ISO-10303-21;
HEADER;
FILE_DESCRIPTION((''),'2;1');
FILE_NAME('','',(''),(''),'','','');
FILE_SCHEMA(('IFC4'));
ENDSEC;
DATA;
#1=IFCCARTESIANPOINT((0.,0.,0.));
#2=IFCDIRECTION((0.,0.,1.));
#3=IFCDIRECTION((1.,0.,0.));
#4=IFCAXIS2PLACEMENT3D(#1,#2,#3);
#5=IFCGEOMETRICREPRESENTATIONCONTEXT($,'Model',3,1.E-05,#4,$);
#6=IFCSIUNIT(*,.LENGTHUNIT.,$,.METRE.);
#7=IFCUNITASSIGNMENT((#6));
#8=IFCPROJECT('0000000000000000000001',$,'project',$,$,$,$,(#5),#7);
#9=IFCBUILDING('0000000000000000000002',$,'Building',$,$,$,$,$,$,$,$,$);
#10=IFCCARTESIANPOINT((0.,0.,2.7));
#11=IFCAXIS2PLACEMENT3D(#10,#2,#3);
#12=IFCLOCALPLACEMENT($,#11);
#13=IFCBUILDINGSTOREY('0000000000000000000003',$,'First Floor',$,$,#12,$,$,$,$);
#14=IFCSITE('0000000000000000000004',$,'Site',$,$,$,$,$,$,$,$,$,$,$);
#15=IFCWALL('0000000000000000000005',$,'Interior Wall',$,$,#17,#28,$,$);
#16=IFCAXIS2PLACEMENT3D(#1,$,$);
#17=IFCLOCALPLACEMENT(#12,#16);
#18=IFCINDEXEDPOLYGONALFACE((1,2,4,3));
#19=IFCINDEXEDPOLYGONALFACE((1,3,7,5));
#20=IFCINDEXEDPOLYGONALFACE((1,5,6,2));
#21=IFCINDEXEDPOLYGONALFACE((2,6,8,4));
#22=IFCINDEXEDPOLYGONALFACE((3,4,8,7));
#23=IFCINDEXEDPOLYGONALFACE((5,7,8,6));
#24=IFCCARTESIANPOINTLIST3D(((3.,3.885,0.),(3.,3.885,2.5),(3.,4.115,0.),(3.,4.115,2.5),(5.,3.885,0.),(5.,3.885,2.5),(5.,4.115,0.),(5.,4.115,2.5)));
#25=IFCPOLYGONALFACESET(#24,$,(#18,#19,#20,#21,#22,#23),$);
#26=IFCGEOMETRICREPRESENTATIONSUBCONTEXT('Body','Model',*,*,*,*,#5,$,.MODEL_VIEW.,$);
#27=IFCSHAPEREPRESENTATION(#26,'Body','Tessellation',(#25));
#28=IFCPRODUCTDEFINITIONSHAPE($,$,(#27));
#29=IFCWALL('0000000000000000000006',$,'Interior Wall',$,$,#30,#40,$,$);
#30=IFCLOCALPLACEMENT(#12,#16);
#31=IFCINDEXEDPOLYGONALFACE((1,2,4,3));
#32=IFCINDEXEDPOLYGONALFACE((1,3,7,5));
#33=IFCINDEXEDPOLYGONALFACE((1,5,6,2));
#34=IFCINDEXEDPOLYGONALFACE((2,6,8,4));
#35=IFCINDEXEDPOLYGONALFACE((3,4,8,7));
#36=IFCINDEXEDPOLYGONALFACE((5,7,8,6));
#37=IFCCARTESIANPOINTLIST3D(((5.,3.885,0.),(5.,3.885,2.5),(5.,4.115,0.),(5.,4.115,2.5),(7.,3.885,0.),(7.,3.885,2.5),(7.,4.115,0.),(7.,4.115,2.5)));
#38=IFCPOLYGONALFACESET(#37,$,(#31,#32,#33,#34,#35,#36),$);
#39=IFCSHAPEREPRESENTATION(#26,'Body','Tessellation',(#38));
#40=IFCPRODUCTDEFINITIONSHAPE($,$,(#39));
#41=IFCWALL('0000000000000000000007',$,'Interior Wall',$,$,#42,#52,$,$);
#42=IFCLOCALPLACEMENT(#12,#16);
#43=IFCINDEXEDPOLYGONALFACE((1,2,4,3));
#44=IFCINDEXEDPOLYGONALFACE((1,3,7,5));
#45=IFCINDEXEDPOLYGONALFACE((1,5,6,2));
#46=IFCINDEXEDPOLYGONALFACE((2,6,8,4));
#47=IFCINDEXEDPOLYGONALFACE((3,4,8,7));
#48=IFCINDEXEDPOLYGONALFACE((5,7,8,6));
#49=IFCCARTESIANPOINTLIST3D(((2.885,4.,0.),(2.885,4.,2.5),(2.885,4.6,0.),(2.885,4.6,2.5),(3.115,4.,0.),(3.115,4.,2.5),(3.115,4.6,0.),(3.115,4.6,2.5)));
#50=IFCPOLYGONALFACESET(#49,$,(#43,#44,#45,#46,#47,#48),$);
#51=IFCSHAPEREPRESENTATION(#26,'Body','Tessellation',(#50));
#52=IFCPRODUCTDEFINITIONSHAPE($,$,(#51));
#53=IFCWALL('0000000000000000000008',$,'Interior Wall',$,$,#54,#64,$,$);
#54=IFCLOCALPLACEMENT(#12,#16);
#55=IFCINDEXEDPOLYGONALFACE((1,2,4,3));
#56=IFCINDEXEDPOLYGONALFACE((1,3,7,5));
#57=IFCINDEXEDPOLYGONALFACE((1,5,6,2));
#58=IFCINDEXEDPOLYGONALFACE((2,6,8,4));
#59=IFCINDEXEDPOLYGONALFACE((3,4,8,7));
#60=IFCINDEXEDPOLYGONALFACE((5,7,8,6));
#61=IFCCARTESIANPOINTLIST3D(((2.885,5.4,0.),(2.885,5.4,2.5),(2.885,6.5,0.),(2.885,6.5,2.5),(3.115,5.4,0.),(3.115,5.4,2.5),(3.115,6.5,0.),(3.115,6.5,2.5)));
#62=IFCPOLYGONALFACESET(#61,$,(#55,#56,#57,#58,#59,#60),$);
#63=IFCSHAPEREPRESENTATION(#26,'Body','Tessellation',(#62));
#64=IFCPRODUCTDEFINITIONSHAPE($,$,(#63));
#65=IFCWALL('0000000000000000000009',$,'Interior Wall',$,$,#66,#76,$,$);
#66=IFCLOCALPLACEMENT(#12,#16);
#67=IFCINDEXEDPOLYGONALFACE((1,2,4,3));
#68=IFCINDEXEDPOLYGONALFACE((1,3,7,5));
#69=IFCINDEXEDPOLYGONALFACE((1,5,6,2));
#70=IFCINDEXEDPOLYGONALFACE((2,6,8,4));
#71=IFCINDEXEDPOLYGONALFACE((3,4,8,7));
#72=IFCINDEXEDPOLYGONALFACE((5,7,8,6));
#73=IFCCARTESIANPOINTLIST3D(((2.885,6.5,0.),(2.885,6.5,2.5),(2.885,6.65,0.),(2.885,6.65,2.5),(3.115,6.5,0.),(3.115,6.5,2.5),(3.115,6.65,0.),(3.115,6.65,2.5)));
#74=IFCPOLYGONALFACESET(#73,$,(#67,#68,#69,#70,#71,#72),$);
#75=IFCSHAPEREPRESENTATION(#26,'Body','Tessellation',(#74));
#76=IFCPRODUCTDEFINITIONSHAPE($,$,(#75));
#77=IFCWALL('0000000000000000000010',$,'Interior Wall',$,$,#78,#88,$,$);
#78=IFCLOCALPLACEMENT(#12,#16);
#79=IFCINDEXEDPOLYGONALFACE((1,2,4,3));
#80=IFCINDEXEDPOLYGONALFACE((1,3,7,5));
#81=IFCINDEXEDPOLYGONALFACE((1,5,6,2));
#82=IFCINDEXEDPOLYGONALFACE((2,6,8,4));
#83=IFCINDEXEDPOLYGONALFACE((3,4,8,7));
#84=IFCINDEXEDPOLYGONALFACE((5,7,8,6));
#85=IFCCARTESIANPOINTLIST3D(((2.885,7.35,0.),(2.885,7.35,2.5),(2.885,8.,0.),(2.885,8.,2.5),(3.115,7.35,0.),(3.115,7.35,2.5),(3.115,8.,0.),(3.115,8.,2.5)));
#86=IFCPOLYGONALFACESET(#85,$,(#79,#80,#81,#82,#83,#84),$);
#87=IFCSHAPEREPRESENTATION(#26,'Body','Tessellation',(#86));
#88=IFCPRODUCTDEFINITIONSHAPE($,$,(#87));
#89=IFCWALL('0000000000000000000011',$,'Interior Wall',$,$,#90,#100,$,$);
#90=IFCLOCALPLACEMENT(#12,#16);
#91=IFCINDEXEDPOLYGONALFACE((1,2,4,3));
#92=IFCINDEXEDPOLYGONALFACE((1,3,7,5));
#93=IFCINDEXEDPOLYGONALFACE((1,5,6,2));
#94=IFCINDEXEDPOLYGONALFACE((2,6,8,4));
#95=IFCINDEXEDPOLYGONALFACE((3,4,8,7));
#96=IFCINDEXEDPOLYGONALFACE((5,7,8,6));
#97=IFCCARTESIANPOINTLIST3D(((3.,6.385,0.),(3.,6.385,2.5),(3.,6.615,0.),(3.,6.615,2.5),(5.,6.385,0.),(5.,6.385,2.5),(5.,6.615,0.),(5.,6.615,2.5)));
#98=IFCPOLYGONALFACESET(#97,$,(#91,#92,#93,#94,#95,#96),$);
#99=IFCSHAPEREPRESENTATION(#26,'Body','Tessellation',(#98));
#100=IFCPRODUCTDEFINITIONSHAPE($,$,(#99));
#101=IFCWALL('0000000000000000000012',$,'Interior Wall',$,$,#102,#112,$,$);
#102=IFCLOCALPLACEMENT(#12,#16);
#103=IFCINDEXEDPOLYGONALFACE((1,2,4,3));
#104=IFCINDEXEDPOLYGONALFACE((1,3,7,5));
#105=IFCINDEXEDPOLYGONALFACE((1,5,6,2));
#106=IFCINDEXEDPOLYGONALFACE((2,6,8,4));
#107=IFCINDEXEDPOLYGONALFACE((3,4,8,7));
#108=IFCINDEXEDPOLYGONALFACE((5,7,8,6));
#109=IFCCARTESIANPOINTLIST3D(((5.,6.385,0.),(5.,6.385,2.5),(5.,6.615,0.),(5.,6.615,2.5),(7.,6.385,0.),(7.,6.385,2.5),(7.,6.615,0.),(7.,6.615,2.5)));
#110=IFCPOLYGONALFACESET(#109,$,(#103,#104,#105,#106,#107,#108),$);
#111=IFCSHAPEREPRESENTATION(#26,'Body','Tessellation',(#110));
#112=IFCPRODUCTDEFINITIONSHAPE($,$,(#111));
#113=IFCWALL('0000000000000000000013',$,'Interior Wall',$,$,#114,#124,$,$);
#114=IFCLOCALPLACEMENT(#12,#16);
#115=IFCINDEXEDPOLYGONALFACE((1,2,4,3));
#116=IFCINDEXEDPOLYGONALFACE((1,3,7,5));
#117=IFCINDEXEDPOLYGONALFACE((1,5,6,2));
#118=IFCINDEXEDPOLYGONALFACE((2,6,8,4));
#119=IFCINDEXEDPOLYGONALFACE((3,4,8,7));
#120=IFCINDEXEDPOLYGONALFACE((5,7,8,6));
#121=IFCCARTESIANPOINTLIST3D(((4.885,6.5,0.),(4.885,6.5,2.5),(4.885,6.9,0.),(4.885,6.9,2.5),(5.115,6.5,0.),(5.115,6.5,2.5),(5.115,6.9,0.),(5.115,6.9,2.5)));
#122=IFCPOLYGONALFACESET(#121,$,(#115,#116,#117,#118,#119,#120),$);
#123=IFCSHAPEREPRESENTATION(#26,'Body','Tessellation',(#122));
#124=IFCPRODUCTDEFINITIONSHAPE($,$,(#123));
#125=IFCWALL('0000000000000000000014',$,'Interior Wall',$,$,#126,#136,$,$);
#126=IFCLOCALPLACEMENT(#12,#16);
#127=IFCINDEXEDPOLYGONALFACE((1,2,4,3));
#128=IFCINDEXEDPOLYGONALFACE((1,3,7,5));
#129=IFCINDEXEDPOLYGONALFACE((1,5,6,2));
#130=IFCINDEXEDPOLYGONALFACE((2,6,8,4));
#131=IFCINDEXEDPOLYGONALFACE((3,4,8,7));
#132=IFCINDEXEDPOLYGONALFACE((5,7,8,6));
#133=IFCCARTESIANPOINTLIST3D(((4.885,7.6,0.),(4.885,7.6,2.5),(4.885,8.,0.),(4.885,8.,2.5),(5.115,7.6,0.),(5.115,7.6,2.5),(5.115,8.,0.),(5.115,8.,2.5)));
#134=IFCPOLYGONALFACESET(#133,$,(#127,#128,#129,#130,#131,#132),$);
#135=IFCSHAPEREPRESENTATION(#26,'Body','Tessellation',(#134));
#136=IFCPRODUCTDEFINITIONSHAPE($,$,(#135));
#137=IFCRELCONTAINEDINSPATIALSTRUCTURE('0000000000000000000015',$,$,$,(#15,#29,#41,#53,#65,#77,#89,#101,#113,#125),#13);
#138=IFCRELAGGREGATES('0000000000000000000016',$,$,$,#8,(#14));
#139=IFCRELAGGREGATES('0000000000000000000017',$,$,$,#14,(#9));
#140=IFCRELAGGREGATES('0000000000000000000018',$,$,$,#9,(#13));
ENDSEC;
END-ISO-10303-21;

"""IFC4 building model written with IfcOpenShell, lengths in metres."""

from ifc_helpers import new_model, si_unit, frame, origin_with_axes, place, context, subcontext, project, spatial, indexed_curve, outline, extrude, element, save


model = new_model("IFC4")

# Units and contexts
model_context = context("Model", 3, precision=1e-05, world=origin_with_axes())
body_context = subcontext(model_context, "Body", "Model", "MODEL_VIEW")
ifc_project = project(units=[si_unit("LENGTHUNIT", "METRE")], contexts=[model_context])

# Site, building, storey
site = spatial("IfcSite", under=ifc_project, Name="Site")
building = spatial("IfcBuilding", under=site, Name="Building")
storey_placement = place(None, frame((0.0, 0.0, 2.7), z_axis=(0.0, 0.0, 1.0), x_axis=(1.0, 0.0, 0.0)))
storey = spatial("IfcBuildingStorey", under=building, at=storey_placement, Name="First Floor")

# Walls
for number, where, z_axis, x_axis, name in (
    (1, (5.0, 4.0, 0.0), (0.0, 0.0, 1.0), (-1.0, 0.0, 0.0), "Interior Wall"),
    (2, (7.0, 4.0, 0.0), (0.0, 0.0, 1.0), (-1.0, 0.0, 0.0), "Interior Wall"),
):
    element("IfcWall", number, at=place(storey_placement, frame(where, z_axis=z_axis, x_axis=x_axis)), inside=storey, Name=name, context=body_context, shape_type="SweptSolid", body=[
        extrude(outline(indexed_curve([(0.0, 0.0), (0.0, 0.23), (2.0, 0.23), (2.0, 0.0), (0.0, 0.0)], self_intersect=False)), frame((0.0, -0.115, 0.0), z_axis=(0.0, 0.0, 1.0), x_axis=(1.0, 0.0, 0.0)), (0.0, 0.0, 1.0), 2.5),
    ])
wall_1_placement = place(storey_placement, frame((3.0, 4.0, 0.0), z_axis=(0.0, 0.0, 1.0), x_axis=(0.0, 1.0, 0.0)))
element("IfcWall", 3, at=wall_1_placement, inside=storey, Name="Interior Wall", context=body_context, shape_type="SweptSolid", body=[
    extrude(outline(indexed_curve([(0.0, 0.0), (0.0, 0.23), (0.6, 0.23), (0.6, 0.0), (0.0, 0.0)], self_intersect=False)), frame((0.0, -0.115, 0.0), z_axis=(0.0, 0.0, 1.0), x_axis=(1.0, 0.0, 0.0)), (0.0, 0.0, 1.0), 2.5),
])
wall_2_placement = place(storey_placement, frame((3.0, 5.4, 0.0), z_axis=(0.0, 0.0, 1.0), x_axis=(0.0, 1.0, 0.0)))
element("IfcWall", 4, at=wall_2_placement, inside=storey, Name="Interior Wall", context=body_context, shape_type="SweptSolid", body=[
    extrude(outline(indexed_curve([(0.0, 0.0), (0.0, 0.23), (1.1, 0.23), (1.1, 0.0), (0.0, 0.0)], self_intersect=False)), frame((0.0, -0.115, 0.0), z_axis=(0.0, 0.0, 1.0), x_axis=(1.0, 0.0, 0.0)), (0.0, 0.0, 1.0), 2.5),
])
wall_3_placement = place(storey_placement, frame((3.0, 6.5, 0.0), z_axis=(0.0, 0.0, 1.0), x_axis=(0.0, 1.0, 0.0)))
element("IfcWall", 5, at=wall_3_placement, inside=storey, Name="Interior Wall", context=body_context, shape_type="SweptSolid", body=[
    extrude(outline(indexed_curve([(0.0, 0.0), (0.0, 0.23), (0.15, 0.23), (0.15, 0.0), (0.0, 0.0)], self_intersect=False)), frame((0.0, -0.115, 0.0), z_axis=(0.0, 0.0, 1.0), x_axis=(1.0, 0.0, 0.0)), (0.0, 0.0, 1.0), 2.5),
])
wall_4_placement = place(storey_placement, frame((3.0, 7.35, 0.0), z_axis=(0.0, 0.0, 1.0), x_axis=(0.0, 1.0, 0.0)))
element("IfcWall", 6, at=wall_4_placement, inside=storey, Name="Interior Wall", context=body_context, shape_type="SweptSolid", body=[
    extrude(outline(indexed_curve([(0.0, 0.0), (0.0, 0.23), (0.65, 0.23), (0.65, 0.0), (0.0, 0.0)], self_intersect=False)), frame((0.0, -0.115, 0.0), z_axis=(0.0, 0.0, 1.0), x_axis=(1.0, 0.0, 0.0)), (0.0, 0.0, 1.0), 2.5),
])
for number, where, z_axis, x_axis, name in (
    (7, (5.0, 6.5, 0.0), (0.0, 0.0, 1.0), (-1.0, 0.0, 0.0), "Interior Wall"),
    (8, (7.0, 6.5, 0.0), (0.0, 0.0, 1.0), (-1.0, 0.0, 0.0), "Interior Wall"),
):
    element("IfcWall", number, at=place(storey_placement, frame(where, z_axis=z_axis, x_axis=x_axis)), inside=storey, Name=name, context=body_context, shape_type="SweptSolid", body=[
        extrude(outline(indexed_curve([(0.0, 0.0), (0.0, 0.23), (2.0, 0.23), (2.0, 0.0), (0.0, 0.0)], self_intersect=False)), frame((0.0, -0.115, 0.0), z_axis=(0.0, 0.0, 1.0), x_axis=(1.0, 0.0, 0.0)), (0.0, 0.0, 1.0), 2.5),
    ])
for number, where, z_axis, x_axis, name in (
    (9, (5.0, 6.5, 0.0), (0.0, 0.0, 1.0), (0.0, 1.0, 0.0), "Interior Wall"),
    (10, (5.0, 7.6, 0.0), (0.0, 0.0, 1.0), (0.0, 1.0, 0.0), "Interior Wall"),
):
    element("IfcWall", number, at=place(storey_placement, frame(where, z_axis=z_axis, x_axis=x_axis)), inside=storey, Name=name, context=body_context, shape_type="SweptSolid", body=[
        extrude(outline(indexed_curve([(0.0, 0.0), (0.0, 0.23), (0.4, 0.23), (0.4, 0.0), (0.0, 0.0)], self_intersect=False)), frame((0.0, -0.115, 0.0), z_axis=(0.0, 0.0, 1.0), x_axis=(1.0, 0.0, 0.0)), (0.0, 0.0, 1.0), 2.5),
    ])

save(model, "model.ifc")
